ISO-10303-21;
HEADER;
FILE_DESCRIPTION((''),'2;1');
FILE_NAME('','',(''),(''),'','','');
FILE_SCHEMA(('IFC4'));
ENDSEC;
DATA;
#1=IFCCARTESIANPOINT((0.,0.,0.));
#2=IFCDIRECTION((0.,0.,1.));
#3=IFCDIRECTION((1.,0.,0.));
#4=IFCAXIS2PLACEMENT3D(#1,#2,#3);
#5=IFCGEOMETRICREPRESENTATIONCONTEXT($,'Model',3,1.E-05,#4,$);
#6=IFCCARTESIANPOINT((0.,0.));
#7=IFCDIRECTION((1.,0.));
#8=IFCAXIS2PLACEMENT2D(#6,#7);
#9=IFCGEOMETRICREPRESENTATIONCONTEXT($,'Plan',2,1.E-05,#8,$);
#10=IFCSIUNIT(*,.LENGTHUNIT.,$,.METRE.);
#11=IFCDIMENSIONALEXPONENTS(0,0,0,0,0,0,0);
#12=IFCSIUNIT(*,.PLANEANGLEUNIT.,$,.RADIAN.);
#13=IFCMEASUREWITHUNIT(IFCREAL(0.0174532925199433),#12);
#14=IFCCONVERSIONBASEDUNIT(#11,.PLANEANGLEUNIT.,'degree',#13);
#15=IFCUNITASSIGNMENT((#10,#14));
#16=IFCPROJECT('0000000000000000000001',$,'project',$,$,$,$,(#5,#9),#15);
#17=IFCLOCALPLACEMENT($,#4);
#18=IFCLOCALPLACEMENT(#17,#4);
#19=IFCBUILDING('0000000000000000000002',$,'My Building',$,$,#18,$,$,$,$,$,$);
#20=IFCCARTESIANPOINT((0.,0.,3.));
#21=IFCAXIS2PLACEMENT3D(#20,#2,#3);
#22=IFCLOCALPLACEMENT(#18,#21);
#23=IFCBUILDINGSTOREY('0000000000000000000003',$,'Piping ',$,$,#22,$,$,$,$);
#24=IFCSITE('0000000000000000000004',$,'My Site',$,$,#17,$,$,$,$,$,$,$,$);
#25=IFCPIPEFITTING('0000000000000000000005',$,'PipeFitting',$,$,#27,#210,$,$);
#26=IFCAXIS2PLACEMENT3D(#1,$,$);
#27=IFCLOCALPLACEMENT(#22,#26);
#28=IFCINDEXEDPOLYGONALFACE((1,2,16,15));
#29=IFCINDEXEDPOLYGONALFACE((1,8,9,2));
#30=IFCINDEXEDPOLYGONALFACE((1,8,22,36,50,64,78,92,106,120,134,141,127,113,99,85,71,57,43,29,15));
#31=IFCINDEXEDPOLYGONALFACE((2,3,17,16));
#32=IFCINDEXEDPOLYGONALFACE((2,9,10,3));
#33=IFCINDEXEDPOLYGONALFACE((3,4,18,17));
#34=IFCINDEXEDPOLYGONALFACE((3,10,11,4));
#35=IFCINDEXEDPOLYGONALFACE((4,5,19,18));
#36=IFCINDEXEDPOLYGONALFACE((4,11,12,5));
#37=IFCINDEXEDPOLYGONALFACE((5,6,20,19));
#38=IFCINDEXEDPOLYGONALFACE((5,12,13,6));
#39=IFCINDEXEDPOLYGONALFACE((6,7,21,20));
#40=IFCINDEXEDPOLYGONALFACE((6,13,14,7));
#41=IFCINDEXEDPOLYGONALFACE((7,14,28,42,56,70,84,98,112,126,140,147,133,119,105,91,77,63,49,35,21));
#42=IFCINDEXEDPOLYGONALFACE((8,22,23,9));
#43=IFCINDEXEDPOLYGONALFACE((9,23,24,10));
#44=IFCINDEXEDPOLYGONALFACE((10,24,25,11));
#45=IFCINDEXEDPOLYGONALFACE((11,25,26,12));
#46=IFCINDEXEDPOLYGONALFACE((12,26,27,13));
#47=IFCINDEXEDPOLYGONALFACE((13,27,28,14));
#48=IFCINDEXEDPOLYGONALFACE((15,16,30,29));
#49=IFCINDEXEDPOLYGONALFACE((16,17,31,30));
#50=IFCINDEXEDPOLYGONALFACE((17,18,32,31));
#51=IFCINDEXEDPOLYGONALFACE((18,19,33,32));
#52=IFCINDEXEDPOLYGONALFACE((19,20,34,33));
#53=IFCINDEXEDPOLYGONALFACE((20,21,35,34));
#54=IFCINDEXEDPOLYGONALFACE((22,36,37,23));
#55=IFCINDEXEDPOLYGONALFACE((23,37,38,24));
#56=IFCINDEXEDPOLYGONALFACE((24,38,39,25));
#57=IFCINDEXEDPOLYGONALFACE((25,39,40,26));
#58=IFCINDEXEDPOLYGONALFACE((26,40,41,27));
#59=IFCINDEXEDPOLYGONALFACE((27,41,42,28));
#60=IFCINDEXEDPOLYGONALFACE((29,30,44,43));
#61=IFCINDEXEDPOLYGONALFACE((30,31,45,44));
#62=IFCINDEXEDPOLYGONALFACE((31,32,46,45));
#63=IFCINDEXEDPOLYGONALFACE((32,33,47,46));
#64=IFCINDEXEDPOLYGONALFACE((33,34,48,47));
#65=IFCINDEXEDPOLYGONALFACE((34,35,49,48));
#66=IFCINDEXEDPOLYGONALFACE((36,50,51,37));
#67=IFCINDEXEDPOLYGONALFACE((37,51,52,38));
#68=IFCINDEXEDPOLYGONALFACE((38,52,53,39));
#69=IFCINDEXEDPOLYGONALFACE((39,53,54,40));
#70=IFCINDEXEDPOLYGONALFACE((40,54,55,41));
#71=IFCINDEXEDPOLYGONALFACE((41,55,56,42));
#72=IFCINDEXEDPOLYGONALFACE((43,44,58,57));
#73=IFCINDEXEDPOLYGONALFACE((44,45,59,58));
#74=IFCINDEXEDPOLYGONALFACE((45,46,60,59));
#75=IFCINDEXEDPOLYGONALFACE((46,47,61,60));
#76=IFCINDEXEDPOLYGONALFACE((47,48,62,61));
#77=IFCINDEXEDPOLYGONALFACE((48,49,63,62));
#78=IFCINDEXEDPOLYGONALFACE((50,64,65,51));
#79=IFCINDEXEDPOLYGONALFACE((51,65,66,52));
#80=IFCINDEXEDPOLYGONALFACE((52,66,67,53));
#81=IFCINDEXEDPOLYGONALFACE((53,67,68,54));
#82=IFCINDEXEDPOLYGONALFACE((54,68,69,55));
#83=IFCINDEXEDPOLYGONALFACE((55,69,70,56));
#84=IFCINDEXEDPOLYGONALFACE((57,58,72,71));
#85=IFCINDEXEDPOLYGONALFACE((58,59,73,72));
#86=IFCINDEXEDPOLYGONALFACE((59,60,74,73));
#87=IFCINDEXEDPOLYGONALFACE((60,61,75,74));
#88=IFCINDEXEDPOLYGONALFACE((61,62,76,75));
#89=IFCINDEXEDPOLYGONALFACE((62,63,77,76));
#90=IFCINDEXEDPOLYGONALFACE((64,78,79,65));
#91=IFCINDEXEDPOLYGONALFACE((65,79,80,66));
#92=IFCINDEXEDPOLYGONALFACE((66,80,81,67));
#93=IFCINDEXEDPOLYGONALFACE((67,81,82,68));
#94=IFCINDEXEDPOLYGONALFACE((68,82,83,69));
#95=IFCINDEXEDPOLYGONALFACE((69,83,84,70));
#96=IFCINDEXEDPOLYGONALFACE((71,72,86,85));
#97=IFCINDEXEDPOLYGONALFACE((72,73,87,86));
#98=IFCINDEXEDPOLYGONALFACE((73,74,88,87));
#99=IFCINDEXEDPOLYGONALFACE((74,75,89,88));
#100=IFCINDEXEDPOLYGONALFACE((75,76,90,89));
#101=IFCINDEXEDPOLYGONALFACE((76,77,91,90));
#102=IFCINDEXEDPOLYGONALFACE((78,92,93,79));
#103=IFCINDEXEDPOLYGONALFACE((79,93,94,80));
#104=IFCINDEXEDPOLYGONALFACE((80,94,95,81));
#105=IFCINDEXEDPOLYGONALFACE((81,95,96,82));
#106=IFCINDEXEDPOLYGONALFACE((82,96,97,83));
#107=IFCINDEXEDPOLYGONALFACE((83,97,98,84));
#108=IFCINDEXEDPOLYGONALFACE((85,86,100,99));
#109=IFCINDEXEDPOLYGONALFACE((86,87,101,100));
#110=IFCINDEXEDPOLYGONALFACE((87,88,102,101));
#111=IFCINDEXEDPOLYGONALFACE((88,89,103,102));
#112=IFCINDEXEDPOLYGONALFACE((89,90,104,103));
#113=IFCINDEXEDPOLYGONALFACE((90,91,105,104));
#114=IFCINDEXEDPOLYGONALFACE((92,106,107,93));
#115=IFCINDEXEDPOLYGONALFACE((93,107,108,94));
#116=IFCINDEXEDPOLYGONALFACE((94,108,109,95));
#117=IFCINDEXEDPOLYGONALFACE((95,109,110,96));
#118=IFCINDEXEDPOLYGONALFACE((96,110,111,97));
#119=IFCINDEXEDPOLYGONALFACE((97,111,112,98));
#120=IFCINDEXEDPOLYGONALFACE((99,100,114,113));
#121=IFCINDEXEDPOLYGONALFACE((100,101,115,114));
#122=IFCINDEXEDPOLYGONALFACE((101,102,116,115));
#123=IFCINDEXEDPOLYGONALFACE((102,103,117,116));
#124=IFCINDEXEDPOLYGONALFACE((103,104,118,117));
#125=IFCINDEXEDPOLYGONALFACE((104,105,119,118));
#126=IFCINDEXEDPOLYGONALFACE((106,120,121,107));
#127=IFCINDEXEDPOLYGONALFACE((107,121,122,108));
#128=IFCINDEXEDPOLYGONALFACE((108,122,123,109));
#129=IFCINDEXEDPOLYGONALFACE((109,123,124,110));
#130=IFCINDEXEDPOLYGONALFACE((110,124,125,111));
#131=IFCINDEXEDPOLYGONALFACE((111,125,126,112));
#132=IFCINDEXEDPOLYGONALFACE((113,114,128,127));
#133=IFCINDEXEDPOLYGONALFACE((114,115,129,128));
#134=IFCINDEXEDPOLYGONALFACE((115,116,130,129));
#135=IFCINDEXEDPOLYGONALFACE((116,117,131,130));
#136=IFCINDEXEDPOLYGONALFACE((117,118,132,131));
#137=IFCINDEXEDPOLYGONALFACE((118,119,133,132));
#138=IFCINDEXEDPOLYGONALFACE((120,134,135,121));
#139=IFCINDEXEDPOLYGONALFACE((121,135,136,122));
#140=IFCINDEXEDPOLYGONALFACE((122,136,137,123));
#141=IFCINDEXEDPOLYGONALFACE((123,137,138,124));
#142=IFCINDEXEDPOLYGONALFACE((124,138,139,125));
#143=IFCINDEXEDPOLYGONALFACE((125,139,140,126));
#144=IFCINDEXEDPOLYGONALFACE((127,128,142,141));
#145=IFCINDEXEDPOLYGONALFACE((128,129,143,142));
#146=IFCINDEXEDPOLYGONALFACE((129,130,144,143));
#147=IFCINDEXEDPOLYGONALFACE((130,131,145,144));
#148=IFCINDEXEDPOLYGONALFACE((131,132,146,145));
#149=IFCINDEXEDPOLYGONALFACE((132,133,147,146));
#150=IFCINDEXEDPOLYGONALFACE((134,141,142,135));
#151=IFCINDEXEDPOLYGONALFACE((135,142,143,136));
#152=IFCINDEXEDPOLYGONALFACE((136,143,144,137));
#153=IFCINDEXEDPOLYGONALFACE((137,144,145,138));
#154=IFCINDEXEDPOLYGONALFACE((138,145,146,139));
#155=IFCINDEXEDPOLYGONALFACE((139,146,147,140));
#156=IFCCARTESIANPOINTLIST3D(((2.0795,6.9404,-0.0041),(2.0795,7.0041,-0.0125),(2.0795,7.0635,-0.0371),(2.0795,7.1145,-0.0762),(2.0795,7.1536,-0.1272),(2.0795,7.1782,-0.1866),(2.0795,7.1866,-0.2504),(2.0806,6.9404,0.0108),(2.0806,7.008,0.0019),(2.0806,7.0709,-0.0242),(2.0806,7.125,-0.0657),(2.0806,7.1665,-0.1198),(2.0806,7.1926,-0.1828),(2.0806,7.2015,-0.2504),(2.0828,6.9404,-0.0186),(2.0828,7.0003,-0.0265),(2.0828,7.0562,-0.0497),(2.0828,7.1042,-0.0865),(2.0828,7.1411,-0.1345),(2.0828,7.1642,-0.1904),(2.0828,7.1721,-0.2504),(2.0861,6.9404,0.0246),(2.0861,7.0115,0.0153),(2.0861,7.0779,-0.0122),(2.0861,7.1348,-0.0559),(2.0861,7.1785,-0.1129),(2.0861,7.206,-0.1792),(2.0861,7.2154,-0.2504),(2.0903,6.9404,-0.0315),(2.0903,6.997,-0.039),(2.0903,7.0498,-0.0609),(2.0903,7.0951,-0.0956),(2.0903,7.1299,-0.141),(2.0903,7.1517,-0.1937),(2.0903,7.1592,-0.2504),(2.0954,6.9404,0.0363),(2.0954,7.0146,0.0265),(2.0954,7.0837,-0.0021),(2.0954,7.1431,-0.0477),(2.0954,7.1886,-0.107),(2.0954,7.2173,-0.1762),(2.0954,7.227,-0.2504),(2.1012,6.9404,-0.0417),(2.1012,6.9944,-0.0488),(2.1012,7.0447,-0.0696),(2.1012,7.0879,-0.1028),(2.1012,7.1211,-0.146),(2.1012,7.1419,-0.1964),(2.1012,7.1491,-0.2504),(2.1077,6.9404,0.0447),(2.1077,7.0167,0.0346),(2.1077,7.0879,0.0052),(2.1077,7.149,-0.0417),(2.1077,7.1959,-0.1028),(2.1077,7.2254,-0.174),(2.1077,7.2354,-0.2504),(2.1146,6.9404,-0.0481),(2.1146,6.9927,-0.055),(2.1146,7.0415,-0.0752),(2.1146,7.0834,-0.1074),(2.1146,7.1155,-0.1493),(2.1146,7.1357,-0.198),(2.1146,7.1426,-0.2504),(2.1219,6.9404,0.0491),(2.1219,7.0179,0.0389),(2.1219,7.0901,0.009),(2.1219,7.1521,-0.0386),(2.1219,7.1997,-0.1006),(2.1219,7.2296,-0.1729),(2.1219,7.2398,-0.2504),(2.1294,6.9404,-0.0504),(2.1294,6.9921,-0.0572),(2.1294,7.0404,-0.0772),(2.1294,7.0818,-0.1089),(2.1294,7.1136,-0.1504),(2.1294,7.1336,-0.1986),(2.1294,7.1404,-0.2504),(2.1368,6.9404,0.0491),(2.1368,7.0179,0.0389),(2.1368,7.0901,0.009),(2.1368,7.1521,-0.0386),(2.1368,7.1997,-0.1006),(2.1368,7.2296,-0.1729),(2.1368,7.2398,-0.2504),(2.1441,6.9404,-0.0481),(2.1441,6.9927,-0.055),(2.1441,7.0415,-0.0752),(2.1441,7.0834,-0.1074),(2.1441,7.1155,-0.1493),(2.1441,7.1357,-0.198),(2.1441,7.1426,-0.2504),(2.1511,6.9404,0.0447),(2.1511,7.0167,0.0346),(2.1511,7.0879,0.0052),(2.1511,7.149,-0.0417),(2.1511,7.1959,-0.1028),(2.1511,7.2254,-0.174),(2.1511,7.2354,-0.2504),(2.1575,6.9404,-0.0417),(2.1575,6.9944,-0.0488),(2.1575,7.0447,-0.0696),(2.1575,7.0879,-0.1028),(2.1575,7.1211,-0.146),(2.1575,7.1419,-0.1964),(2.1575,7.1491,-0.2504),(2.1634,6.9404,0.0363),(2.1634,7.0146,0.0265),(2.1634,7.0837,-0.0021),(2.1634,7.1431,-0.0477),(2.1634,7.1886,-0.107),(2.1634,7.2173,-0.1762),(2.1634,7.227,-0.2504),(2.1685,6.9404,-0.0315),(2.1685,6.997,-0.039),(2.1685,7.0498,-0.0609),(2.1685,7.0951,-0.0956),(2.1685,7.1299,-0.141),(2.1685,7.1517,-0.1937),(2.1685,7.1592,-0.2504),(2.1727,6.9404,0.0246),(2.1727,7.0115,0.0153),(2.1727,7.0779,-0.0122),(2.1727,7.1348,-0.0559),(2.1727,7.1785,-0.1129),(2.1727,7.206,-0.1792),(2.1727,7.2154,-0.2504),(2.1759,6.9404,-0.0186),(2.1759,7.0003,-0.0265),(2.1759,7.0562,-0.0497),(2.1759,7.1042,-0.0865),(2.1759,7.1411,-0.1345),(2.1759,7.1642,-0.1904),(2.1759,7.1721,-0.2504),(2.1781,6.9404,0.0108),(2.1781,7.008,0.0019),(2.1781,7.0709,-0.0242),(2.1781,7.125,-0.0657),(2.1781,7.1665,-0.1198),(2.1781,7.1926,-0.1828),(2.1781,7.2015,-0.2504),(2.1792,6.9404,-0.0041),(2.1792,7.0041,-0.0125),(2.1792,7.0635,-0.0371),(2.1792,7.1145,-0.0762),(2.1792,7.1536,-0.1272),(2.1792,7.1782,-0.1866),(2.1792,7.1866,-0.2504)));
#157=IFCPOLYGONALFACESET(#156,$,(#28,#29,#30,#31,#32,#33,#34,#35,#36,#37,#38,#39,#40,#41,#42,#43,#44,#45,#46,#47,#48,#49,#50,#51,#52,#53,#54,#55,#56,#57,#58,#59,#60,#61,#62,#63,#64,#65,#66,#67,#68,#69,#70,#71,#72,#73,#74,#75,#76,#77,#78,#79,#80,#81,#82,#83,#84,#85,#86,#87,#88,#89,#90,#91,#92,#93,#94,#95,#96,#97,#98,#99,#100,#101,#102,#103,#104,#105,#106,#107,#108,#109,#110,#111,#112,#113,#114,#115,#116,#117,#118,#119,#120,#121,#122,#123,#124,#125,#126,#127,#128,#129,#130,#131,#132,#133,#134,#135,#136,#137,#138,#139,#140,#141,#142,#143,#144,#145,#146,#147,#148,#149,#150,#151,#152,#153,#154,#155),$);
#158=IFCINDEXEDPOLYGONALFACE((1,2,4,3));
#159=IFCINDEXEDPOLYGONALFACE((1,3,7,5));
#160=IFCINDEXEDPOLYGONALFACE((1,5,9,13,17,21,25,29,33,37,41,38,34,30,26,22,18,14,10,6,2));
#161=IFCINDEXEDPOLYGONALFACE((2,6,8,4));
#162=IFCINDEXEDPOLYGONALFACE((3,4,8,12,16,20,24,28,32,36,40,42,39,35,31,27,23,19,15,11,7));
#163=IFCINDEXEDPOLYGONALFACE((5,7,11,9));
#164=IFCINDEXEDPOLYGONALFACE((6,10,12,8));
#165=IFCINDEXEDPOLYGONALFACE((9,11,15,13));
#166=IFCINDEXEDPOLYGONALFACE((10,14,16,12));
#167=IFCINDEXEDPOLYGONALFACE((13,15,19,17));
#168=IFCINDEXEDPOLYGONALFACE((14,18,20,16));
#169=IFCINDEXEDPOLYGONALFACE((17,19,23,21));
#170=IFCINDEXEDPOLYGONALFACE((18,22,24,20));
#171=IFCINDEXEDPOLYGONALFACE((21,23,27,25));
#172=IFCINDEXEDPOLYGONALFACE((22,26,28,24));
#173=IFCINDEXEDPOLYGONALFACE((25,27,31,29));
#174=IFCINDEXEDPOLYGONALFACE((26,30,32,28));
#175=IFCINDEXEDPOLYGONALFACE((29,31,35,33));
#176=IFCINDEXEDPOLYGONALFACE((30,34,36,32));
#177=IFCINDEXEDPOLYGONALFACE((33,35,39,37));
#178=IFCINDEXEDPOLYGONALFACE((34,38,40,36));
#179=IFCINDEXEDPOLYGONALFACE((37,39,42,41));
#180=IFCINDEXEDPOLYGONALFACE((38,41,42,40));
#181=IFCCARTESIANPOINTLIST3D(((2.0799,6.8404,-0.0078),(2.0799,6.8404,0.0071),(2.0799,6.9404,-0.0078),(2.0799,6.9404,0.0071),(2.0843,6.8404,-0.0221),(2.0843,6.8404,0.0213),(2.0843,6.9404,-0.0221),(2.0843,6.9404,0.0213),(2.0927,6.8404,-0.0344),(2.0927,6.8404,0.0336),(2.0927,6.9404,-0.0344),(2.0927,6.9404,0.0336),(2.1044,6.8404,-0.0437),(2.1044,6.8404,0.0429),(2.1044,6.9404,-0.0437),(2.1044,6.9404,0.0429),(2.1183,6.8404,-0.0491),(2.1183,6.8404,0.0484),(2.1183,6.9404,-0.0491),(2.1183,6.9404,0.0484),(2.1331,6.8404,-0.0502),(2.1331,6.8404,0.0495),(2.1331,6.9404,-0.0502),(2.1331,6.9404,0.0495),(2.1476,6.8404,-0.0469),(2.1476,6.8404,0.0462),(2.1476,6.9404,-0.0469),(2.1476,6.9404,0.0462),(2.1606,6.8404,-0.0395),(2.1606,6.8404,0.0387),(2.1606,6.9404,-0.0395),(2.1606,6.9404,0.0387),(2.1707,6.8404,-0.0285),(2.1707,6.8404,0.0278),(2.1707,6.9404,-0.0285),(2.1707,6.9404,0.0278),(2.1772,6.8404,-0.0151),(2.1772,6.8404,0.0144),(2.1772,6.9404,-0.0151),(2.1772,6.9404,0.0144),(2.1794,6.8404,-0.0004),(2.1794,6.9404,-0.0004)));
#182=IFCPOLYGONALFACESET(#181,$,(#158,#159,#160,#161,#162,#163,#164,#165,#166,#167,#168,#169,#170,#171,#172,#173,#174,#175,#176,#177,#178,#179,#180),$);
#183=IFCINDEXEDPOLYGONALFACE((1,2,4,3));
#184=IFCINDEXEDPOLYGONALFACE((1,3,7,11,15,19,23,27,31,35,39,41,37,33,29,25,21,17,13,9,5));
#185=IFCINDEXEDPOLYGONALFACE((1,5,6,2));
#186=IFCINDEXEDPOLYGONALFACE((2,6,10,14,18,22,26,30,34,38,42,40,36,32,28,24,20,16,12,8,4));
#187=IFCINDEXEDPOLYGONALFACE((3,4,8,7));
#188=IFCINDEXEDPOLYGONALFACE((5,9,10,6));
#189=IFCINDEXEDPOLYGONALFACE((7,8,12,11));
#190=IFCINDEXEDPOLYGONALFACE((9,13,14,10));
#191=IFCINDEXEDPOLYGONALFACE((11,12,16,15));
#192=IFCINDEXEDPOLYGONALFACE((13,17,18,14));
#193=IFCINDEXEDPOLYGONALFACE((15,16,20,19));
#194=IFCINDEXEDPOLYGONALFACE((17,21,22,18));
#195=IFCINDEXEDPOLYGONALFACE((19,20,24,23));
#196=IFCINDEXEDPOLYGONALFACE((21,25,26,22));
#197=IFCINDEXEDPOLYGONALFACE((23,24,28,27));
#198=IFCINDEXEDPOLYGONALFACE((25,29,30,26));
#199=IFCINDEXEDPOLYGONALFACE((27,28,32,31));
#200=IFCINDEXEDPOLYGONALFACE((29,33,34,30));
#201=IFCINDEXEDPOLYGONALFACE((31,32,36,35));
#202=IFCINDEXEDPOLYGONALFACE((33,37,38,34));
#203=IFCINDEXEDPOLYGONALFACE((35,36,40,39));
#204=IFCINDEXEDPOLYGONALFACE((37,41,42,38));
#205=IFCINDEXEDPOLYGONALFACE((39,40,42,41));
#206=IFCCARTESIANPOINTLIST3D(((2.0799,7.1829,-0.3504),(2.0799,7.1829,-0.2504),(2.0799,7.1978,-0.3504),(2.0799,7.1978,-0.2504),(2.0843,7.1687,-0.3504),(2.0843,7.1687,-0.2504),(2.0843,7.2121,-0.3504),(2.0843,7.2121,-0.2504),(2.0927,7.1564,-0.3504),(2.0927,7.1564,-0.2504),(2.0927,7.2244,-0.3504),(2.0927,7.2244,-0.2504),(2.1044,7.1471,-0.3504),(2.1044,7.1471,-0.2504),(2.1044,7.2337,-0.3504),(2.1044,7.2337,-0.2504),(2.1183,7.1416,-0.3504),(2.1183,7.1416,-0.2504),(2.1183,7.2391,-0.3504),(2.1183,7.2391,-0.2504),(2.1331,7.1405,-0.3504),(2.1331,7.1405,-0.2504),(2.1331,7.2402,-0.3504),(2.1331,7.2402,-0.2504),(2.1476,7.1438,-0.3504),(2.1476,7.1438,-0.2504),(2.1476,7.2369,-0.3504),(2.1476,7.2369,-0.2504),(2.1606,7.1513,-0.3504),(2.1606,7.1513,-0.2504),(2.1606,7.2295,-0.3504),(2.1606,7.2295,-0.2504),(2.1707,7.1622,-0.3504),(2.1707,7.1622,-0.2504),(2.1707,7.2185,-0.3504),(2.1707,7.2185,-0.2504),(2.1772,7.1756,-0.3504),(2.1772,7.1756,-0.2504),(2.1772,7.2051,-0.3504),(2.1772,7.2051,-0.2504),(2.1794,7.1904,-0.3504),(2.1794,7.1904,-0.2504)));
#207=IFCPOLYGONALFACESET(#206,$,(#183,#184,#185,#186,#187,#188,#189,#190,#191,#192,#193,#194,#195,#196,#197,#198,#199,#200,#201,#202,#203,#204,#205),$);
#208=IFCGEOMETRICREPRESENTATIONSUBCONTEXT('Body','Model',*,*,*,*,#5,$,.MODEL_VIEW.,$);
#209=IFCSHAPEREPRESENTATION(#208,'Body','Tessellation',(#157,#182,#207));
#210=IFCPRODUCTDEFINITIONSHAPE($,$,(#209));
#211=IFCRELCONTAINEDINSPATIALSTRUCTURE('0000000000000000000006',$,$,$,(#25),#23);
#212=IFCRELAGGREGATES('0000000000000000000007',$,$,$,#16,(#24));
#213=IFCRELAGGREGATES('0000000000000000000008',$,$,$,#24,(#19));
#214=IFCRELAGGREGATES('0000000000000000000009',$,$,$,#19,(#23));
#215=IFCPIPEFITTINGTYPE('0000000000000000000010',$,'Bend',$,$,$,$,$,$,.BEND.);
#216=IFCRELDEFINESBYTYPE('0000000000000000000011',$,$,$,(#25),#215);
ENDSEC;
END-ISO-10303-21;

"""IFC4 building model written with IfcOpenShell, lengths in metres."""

from ifc_helpers import new_model, entity, si_unit, converted_unit, frame, origin_with_axes, origin_2d_with_axis, place, context, subcontext, project, spatial, circle, extrude, source, transform, mapped, type_object, type_shapes, element, save


model = new_model("IFC4")

# Units and contexts
model_context = context("Model", 3, precision=1e-05, world=origin_with_axes())
plan_context = context("Plan", 2, precision=1e-05, world=origin_2d_with_axis())
body_context = subcontext(model_context, "Body", "Model", "MODEL_VIEW")
ifc_project = project(units=[si_unit("LENGTHUNIT", "METRE"), converted_unit("PLANEANGLEUNIT", "degree", entity("IfcReal", 0.0174532925199433), si_unit("PLANEANGLEUNIT", "RADIAN"), dimensions=[0, 0, 0, 0, 0, 0, 0])], contexts=[model_context, plan_context])

# Site, building, storey
site_placement = place(None, origin_with_axes())
site = spatial("IfcSite", under=ifc_project, at=site_placement, Name="My Site")
building_placement = place(site_placement, origin_with_axes())
building = spatial("IfcBuilding", under=site, at=building_placement, Name="My Building")
storey_placement = place(building_placement, frame((0.0, 0.0, 3.0), z_axis=(0.0, 0.0, 1.0), x_axis=(1.0, 0.0, 0.0)))
storey = spatial("IfcBuildingStorey", under=building, at=storey_placement, Name="Piping ")

# Pipe fitting
pipe_fitting_type = type_object("IfcPipeFittingType", Name="Bend", PredefinedType="BEND")
shared_shape = source(origin_with_axes(), body_context, "Body", "SolidModel", [
    entity("IfcSweptDiskSolid", entity("IfcIndexedPolyCurve", entity("IfcCartesianPointList3D", [[0.0, 0.0, -0.1], [0.0, -0.0732, -0.2768], [0.0, -0.25, -0.35]]), [entity("IfcArcIndex", [1, 2, 3])]), 0.05),
    extrude(circle(Radius=0.05), origin_with_axes(), (0.0, 0.0, -1.0), 0.1),
    extrude(circle(Radius=0.05), frame((0.0, -0.25, -0.35), z_axis=(0.0, -1.0, 0.0), x_axis=(1.0, 0.0, 0.0)), (0.0, 0.0, 1.0), 0.1),
])
type_shapes(pipe_fitting_type, [shared_shape])
for number, where, z_axis, x_axis, name in (
    (1, (2.1294, 6.8404, -0.0004), (0.0, -1.0, 0.0), (1.0, 0.0, 0.0), "PipeFitting"),
):
    element("IfcPipeFitting", number, at=place(storey_placement, frame(where, z_axis=z_axis, x_axis=x_axis)), inside=storey, type_object=pipe_fitting_type, Name=name, context=body_context, shape_type="MappedRepresentation", body=[
        mapped(shared_shape, transform((0.0, 0.0, 0.0), x_axis=(1.0, 0.0, 0.0), y_axis=(0.0, 1.0, 0.0), z_axis=(0.0, 0.0, 1.0), scale=1.0)),
    ])

save(model, "model.ifc")
